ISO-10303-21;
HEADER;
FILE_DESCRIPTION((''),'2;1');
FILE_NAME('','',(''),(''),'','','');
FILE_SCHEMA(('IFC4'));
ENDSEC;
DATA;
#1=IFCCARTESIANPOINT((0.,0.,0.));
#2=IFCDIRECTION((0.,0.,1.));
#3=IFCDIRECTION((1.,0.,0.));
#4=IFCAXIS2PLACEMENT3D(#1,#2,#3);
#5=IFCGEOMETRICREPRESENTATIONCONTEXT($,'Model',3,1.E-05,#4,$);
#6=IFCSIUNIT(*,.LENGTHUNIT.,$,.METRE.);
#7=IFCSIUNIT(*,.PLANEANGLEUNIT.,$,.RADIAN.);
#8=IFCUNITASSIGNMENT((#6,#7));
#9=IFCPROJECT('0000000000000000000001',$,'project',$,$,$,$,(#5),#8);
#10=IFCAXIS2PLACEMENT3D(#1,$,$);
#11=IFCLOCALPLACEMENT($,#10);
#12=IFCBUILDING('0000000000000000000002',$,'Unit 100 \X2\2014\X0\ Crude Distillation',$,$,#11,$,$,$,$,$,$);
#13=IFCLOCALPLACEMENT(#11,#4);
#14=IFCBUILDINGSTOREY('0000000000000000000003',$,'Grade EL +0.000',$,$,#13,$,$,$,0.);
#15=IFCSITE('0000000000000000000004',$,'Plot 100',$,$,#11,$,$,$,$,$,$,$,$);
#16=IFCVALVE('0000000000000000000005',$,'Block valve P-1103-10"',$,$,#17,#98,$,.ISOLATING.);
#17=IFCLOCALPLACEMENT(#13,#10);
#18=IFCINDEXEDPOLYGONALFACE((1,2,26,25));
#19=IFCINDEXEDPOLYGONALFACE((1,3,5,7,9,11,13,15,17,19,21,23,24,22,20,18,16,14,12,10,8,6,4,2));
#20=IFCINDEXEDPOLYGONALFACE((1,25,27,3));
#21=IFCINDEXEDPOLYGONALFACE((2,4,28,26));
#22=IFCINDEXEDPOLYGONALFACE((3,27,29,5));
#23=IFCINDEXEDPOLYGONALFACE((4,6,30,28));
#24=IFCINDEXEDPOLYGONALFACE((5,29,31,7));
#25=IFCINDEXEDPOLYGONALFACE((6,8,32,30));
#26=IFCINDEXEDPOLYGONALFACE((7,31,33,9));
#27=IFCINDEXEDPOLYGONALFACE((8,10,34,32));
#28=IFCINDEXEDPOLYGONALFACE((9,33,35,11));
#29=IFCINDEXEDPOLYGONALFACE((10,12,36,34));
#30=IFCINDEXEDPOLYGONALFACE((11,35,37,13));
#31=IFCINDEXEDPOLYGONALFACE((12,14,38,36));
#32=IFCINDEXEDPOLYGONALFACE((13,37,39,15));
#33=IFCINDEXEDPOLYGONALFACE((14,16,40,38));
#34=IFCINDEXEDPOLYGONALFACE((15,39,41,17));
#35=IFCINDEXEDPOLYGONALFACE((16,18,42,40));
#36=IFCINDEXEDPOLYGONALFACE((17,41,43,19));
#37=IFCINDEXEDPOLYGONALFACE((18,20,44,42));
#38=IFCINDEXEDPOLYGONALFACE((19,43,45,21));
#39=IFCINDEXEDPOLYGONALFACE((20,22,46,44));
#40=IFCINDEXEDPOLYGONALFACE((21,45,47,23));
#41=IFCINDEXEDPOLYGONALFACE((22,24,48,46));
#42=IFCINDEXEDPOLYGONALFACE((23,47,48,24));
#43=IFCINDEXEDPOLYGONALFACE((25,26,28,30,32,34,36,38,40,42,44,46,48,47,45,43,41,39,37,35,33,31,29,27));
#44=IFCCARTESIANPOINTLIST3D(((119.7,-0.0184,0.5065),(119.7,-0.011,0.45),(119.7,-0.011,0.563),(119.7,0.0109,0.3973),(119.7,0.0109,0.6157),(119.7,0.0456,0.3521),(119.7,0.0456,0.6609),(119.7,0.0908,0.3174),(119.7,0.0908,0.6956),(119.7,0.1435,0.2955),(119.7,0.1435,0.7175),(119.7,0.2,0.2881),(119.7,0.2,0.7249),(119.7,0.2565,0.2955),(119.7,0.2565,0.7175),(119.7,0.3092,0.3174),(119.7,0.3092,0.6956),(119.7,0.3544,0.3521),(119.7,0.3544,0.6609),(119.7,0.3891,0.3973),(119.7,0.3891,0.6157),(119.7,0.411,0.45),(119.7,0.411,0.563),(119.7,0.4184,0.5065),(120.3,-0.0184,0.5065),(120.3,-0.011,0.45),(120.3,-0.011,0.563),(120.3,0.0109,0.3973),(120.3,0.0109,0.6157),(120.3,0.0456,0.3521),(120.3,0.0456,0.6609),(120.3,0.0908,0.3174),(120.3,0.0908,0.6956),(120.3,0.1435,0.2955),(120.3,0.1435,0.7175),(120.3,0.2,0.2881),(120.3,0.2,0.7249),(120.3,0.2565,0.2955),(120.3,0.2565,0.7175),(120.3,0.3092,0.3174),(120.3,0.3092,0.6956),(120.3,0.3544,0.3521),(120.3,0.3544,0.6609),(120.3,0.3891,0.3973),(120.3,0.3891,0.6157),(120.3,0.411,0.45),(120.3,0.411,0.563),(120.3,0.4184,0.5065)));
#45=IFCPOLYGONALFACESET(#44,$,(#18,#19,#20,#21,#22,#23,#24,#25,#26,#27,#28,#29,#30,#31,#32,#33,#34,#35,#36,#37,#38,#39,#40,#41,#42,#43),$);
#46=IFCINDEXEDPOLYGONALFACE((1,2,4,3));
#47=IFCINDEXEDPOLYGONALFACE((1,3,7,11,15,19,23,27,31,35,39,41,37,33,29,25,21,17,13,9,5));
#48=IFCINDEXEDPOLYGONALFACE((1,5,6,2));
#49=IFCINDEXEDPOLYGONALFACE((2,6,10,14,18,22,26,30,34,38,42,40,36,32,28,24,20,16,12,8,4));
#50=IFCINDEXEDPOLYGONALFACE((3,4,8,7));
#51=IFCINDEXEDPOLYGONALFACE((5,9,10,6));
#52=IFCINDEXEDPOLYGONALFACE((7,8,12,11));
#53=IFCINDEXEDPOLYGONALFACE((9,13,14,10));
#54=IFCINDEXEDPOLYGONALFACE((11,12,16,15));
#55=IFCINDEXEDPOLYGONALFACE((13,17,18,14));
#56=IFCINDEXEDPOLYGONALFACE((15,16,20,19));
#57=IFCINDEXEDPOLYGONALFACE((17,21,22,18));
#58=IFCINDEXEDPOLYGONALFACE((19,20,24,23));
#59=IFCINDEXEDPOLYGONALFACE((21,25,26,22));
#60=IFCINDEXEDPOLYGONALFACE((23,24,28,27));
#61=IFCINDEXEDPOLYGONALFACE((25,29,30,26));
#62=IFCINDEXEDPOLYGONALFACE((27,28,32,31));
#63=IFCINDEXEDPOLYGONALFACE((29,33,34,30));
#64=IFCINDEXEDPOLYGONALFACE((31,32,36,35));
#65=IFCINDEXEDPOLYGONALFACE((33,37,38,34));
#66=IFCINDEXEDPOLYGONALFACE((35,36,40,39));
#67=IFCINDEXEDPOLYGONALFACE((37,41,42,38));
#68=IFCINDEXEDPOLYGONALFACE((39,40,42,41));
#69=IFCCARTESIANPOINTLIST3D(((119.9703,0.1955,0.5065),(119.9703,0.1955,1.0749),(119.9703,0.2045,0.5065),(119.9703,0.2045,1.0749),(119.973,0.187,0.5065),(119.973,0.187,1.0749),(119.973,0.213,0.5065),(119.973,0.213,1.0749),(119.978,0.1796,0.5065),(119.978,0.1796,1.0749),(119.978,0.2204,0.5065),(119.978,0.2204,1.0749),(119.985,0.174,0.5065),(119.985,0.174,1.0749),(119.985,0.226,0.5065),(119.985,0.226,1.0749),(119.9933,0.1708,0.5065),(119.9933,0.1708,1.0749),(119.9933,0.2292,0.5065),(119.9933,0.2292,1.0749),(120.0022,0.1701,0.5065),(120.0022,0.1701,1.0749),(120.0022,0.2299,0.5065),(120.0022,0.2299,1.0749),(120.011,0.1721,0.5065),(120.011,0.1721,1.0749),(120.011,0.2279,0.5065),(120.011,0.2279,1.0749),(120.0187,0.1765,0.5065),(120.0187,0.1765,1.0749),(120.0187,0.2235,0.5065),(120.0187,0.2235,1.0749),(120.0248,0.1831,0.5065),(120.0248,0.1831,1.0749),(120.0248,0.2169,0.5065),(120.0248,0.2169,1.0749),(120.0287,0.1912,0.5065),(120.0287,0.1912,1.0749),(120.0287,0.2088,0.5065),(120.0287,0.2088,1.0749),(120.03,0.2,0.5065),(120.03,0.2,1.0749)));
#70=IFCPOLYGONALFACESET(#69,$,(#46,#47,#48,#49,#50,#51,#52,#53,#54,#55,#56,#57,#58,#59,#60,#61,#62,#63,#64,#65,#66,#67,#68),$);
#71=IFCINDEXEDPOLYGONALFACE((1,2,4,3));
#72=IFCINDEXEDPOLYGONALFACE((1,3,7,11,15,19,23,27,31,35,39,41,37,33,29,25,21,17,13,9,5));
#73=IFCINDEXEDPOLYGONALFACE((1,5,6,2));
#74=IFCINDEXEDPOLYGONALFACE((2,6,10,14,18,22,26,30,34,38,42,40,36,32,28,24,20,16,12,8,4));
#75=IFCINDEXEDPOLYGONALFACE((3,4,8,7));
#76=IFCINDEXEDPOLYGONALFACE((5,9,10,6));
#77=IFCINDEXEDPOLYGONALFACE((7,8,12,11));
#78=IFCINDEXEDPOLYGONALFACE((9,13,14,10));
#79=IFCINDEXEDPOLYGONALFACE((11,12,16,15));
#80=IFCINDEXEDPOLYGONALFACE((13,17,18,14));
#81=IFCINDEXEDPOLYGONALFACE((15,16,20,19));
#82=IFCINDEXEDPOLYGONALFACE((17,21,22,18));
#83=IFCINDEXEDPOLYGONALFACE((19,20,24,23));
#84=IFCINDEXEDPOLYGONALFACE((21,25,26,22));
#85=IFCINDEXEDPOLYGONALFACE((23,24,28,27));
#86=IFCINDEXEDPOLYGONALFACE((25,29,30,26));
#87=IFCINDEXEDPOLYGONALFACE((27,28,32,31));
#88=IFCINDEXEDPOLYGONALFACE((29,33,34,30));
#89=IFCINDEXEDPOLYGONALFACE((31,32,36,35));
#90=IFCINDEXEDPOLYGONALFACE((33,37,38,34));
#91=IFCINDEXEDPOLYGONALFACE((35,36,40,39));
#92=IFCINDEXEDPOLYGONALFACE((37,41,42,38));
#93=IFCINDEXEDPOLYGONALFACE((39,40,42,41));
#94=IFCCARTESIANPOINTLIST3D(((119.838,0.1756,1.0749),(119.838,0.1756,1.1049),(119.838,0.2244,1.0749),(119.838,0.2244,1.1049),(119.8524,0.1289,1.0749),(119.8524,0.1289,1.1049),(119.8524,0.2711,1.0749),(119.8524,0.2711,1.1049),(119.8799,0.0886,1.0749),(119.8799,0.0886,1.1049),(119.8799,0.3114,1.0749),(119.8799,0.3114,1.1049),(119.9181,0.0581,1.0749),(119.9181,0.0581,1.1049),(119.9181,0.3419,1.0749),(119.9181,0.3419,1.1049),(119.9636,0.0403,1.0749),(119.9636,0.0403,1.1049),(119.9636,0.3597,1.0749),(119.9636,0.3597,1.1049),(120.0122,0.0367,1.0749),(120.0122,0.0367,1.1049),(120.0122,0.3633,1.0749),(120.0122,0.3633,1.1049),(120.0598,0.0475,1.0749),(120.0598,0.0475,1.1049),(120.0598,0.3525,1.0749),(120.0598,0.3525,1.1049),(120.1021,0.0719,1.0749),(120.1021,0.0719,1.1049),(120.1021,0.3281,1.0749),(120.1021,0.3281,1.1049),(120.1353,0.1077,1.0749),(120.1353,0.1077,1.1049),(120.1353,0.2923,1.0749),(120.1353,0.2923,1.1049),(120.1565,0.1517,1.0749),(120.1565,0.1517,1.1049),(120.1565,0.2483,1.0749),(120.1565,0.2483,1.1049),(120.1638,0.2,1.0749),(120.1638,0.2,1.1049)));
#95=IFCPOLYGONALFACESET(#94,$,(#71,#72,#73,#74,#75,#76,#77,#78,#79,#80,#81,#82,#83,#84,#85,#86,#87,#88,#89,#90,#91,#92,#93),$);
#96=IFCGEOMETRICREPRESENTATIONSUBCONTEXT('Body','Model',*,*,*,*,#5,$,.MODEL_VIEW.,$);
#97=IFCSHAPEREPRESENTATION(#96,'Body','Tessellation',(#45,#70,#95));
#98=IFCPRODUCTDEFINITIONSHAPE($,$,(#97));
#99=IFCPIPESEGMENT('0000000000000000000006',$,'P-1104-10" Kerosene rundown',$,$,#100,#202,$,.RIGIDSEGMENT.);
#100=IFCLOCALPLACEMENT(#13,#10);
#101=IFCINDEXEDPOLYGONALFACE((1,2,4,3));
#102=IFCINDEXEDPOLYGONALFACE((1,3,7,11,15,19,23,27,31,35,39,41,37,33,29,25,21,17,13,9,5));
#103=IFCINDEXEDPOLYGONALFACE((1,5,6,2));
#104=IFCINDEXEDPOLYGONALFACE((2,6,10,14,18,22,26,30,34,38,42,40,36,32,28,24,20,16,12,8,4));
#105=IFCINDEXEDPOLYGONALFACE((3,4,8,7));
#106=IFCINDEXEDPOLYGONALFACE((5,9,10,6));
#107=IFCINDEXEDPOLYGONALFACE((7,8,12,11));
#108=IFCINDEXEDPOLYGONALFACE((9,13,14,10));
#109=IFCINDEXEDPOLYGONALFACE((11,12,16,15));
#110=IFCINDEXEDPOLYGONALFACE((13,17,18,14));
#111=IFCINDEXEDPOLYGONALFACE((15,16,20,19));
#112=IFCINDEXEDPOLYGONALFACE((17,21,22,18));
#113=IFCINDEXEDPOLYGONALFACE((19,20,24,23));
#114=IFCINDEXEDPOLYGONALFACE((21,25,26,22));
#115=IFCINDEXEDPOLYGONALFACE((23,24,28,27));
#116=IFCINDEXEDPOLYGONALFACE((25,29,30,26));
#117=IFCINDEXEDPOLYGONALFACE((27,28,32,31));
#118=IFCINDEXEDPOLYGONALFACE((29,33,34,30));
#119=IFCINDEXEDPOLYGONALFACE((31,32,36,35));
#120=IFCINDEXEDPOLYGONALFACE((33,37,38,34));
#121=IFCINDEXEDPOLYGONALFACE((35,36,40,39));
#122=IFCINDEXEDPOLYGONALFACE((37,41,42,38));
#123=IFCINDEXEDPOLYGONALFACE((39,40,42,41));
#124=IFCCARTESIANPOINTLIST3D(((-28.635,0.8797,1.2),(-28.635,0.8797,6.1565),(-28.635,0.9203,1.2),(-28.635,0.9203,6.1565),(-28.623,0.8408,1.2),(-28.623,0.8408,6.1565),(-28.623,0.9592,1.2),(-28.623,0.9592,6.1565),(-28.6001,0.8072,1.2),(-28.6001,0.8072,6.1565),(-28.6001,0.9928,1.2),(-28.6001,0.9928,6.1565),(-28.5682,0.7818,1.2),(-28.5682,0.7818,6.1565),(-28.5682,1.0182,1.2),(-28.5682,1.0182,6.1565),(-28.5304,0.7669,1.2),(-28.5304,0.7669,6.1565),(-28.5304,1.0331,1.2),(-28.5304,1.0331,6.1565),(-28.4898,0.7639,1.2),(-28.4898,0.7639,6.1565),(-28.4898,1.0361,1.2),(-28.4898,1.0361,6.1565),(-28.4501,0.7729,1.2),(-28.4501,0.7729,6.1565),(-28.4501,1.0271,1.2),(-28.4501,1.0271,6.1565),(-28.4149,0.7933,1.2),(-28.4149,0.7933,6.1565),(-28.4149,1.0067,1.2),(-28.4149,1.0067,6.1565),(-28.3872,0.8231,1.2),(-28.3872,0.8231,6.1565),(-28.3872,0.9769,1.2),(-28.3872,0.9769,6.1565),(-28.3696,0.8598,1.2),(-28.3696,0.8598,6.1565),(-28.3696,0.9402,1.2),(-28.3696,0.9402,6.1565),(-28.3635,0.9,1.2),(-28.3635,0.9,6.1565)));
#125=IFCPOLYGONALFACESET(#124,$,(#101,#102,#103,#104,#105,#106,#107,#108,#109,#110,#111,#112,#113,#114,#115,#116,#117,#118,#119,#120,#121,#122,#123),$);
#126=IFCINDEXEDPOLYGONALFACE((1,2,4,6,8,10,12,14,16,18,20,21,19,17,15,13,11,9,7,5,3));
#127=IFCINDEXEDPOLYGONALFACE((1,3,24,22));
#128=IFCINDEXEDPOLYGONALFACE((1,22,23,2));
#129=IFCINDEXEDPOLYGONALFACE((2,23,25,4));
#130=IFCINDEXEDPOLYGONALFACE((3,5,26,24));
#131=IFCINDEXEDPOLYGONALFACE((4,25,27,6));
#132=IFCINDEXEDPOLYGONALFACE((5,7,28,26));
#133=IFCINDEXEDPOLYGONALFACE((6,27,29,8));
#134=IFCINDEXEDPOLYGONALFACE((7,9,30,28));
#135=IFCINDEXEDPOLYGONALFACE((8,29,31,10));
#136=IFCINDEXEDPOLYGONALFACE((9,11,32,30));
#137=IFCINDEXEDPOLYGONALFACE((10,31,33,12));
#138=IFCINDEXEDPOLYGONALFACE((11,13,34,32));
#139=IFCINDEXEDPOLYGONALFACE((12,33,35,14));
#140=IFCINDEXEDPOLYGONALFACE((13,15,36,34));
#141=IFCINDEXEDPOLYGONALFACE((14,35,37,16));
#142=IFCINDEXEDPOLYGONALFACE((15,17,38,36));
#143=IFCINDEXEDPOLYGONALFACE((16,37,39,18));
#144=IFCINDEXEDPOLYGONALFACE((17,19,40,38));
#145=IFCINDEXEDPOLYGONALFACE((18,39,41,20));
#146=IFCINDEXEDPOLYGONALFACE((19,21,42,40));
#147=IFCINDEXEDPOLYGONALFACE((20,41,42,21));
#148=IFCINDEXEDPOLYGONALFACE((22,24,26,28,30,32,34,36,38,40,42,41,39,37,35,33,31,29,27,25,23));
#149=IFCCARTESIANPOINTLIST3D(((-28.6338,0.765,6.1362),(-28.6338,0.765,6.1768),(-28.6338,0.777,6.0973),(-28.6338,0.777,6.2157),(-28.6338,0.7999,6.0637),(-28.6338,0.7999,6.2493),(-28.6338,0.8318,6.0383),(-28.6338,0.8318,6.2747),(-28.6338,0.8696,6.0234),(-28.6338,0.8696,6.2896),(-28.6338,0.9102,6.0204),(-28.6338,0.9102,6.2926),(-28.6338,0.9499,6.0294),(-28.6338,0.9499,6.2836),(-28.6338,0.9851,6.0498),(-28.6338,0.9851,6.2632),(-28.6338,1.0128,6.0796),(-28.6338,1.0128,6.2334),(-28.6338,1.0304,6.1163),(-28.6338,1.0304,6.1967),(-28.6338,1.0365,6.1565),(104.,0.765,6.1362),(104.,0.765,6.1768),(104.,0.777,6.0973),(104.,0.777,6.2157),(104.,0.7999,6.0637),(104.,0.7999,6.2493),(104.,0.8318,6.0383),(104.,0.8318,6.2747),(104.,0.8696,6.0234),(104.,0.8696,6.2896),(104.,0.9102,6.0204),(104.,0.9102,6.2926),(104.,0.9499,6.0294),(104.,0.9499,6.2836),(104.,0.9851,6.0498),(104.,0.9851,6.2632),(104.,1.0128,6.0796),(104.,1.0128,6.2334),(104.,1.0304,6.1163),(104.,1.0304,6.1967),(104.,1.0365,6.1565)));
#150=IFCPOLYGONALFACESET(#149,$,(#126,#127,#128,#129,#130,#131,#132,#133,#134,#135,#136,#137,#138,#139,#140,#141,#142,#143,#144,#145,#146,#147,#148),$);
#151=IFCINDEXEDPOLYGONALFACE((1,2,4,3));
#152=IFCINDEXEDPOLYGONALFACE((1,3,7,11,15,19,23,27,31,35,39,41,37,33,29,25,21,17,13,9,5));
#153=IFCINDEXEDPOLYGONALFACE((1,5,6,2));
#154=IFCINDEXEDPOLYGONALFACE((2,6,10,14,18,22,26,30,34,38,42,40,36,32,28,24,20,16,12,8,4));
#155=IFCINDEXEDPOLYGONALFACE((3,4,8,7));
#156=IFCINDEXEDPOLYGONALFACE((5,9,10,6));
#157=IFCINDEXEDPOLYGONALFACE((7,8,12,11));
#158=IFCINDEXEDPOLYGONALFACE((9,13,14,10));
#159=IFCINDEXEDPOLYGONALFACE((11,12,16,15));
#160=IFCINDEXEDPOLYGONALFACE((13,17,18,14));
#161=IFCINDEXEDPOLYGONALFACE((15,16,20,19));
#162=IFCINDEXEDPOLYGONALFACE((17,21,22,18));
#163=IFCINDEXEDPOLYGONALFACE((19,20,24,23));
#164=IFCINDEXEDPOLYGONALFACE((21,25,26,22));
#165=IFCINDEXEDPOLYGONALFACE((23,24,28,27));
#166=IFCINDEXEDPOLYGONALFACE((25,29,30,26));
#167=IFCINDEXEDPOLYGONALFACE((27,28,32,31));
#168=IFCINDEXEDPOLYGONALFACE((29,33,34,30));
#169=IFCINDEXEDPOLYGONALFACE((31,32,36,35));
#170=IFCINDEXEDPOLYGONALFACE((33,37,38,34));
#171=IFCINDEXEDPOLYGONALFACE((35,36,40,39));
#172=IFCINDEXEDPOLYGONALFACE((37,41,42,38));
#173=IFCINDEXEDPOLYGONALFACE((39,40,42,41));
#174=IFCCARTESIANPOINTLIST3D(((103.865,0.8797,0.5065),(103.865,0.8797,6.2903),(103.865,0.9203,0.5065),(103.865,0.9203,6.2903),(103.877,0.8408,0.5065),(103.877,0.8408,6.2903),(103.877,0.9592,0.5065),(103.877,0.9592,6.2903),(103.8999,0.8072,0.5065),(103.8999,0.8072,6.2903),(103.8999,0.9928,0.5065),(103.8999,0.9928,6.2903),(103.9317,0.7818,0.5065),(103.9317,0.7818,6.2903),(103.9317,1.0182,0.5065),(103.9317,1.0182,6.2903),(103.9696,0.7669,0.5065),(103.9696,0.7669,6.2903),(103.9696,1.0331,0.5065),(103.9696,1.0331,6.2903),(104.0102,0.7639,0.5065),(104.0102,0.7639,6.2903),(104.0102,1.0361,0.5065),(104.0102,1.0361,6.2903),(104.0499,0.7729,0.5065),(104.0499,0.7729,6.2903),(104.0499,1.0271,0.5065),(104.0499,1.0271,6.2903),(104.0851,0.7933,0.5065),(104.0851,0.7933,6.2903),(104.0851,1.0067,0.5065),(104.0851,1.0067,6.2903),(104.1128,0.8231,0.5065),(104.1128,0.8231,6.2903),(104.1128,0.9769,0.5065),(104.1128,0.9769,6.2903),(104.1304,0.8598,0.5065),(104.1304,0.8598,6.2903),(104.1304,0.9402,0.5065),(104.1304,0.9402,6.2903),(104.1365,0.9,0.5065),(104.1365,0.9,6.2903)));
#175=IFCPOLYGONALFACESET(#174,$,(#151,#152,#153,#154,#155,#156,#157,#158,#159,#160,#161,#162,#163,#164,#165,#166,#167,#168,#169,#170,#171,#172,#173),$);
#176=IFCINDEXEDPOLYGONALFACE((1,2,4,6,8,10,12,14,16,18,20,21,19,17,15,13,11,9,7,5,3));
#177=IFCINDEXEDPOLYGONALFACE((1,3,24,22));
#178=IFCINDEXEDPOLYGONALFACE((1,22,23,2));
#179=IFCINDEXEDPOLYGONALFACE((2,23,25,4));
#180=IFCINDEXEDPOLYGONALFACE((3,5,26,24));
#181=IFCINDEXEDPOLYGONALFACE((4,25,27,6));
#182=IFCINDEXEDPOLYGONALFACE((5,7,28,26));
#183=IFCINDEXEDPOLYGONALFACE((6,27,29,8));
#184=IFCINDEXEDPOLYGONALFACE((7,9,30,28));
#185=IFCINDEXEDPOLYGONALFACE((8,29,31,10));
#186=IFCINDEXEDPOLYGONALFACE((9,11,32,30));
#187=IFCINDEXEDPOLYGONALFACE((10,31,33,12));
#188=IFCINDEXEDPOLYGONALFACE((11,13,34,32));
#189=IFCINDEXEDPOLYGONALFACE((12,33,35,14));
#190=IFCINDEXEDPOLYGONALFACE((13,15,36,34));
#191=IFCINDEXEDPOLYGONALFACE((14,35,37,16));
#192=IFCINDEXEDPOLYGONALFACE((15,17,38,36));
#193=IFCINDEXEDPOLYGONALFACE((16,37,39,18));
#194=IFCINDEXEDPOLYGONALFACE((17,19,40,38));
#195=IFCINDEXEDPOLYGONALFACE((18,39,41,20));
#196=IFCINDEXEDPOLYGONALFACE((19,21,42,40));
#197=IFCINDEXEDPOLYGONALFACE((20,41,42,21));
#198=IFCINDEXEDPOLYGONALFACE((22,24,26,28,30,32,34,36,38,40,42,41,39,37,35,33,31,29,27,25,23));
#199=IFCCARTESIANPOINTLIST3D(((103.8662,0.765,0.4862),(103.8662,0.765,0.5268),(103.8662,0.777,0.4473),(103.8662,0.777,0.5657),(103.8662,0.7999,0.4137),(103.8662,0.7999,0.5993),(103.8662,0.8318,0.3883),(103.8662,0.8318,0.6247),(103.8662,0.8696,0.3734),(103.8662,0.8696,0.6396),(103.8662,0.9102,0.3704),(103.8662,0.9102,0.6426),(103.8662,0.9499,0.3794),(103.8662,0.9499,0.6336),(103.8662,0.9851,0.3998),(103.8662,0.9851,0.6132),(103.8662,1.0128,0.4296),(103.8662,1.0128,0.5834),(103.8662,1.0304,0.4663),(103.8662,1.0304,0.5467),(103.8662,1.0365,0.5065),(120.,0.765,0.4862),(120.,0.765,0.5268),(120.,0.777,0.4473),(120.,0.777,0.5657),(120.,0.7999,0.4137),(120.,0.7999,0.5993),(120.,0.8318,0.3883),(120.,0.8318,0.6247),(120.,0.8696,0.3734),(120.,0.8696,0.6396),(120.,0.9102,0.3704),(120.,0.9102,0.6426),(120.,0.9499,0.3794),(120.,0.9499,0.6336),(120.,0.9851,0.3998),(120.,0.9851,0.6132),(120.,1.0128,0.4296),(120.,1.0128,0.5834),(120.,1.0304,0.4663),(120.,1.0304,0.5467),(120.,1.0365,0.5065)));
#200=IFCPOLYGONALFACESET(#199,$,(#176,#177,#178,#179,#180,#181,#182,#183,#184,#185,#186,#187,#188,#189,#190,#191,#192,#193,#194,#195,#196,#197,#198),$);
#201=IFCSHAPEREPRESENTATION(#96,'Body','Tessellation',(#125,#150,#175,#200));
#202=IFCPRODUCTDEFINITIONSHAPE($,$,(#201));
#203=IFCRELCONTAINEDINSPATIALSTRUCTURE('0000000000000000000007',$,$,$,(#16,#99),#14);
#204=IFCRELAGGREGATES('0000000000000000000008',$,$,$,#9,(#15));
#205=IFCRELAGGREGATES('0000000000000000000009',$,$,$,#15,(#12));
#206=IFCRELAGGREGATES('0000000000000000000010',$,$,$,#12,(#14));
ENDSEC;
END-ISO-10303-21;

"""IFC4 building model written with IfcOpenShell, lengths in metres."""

from ifc_helpers import new_model, si_unit, frame, origin, origin_with_axes, origin_2d, place, context, subcontext, project, spatial, circle, extrude, element, save


model = new_model("IFC4")

# Units and contexts
model_context = context("Model", 3, precision=1e-05, world=origin_with_axes())
body_context = subcontext(model_context, "Body", "Model", "MODEL_VIEW")
ifc_project = project(units=[si_unit("LENGTHUNIT", "METRE"), si_unit("PLANEANGLEUNIT", "RADIAN")], contexts=[model_context])

# Site, building, storey
placement = place(None, origin())
site = spatial("IfcSite", under=ifc_project, at=placement, Name="Plot 100")
building = spatial("IfcBuilding", under=site, at=placement, Name="Unit 100 — Crude Distillation")
storey_placement = place(placement, origin_with_axes())
storey = spatial("IfcBuildingStorey", under=building, at=storey_placement, Name="Grade EL +0.000", Elevation=0.0)

# Valve
valve_1_placement = place(storey_placement, origin_with_axes())
element("IfcValve", 1, at=valve_1_placement, inside=storey, Name="Block valve P-1103-10\"", PredefinedType="ISOLATING", context=body_context, shape_type="SweptSolid", body=[
    extrude(circle(Radius=0.2184, at=origin_2d()), frame((119.7, 0.2, 0.5065), z_axis=(1.0, 0.0, 0.0), x_axis=(0.0, 1.0, 0.0)), (0.0, 0.0, 1.0), 0.6),
    extrude(circle(Radius=0.03, at=origin_2d()), frame((120.0, 0.2, 0.5065), z_axis=(0.0, 0.0, 1.0), x_axis=(1.0, 0.0, 0.0)), (0.0, 0.0, 1.0), 0.5684),
    extrude(circle(Radius=0.1638, at=origin_2d()), frame((120.0, 0.2, 1.0749), z_axis=(0.0, 0.0, 1.0), x_axis=(1.0, 0.0, 0.0)), (0.0, 0.0, 1.0), 0.03),
])

# Pipe segment
pipe_segment_1_placement = place(storey_placement, origin_with_axes())
element("IfcPipeSegment", 2, at=pipe_segment_1_placement, inside=storey, Name="P-1104-10\" Kerosene rundown", PredefinedType="RIGIDSEGMENT", context=body_context, shape_type="SweptSolid", body=[
    extrude(circle(Radius=0.1365, at=origin_2d()), frame((-28.5, 0.9, 1.2), z_axis=(0.0, 0.0, 1.0), x_axis=(1.0, 0.0, 0.0)), (0.0, 0.0, 1.0), 4.9565),
    extrude(circle(Radius=0.1365, at=origin_2d()), frame((-28.6338, 0.9, 6.1565), z_axis=(1.0, 0.0, 0.0), x_axis=(0.0, 1.0, 0.0)), (0.0, 0.0, 1.0), 132.6338),
    extrude(circle(Radius=0.1365, at=origin_2d()), frame((104.0, 0.9, 6.2903), z_axis=(0.0, 0.0, -1.0), x_axis=(1.0, 0.0, 0.0)), (0.0, 0.0, 1.0), 5.7838),
    extrude(circle(Radius=0.1365, at=origin_2d()), frame((103.8662, 0.9, 0.5065), z_axis=(1.0, 0.0, 0.0), x_axis=(0.0, 1.0, 0.0)), (0.0, 0.0, 1.0), 16.1338),
])

save(model, "model.ifc")
